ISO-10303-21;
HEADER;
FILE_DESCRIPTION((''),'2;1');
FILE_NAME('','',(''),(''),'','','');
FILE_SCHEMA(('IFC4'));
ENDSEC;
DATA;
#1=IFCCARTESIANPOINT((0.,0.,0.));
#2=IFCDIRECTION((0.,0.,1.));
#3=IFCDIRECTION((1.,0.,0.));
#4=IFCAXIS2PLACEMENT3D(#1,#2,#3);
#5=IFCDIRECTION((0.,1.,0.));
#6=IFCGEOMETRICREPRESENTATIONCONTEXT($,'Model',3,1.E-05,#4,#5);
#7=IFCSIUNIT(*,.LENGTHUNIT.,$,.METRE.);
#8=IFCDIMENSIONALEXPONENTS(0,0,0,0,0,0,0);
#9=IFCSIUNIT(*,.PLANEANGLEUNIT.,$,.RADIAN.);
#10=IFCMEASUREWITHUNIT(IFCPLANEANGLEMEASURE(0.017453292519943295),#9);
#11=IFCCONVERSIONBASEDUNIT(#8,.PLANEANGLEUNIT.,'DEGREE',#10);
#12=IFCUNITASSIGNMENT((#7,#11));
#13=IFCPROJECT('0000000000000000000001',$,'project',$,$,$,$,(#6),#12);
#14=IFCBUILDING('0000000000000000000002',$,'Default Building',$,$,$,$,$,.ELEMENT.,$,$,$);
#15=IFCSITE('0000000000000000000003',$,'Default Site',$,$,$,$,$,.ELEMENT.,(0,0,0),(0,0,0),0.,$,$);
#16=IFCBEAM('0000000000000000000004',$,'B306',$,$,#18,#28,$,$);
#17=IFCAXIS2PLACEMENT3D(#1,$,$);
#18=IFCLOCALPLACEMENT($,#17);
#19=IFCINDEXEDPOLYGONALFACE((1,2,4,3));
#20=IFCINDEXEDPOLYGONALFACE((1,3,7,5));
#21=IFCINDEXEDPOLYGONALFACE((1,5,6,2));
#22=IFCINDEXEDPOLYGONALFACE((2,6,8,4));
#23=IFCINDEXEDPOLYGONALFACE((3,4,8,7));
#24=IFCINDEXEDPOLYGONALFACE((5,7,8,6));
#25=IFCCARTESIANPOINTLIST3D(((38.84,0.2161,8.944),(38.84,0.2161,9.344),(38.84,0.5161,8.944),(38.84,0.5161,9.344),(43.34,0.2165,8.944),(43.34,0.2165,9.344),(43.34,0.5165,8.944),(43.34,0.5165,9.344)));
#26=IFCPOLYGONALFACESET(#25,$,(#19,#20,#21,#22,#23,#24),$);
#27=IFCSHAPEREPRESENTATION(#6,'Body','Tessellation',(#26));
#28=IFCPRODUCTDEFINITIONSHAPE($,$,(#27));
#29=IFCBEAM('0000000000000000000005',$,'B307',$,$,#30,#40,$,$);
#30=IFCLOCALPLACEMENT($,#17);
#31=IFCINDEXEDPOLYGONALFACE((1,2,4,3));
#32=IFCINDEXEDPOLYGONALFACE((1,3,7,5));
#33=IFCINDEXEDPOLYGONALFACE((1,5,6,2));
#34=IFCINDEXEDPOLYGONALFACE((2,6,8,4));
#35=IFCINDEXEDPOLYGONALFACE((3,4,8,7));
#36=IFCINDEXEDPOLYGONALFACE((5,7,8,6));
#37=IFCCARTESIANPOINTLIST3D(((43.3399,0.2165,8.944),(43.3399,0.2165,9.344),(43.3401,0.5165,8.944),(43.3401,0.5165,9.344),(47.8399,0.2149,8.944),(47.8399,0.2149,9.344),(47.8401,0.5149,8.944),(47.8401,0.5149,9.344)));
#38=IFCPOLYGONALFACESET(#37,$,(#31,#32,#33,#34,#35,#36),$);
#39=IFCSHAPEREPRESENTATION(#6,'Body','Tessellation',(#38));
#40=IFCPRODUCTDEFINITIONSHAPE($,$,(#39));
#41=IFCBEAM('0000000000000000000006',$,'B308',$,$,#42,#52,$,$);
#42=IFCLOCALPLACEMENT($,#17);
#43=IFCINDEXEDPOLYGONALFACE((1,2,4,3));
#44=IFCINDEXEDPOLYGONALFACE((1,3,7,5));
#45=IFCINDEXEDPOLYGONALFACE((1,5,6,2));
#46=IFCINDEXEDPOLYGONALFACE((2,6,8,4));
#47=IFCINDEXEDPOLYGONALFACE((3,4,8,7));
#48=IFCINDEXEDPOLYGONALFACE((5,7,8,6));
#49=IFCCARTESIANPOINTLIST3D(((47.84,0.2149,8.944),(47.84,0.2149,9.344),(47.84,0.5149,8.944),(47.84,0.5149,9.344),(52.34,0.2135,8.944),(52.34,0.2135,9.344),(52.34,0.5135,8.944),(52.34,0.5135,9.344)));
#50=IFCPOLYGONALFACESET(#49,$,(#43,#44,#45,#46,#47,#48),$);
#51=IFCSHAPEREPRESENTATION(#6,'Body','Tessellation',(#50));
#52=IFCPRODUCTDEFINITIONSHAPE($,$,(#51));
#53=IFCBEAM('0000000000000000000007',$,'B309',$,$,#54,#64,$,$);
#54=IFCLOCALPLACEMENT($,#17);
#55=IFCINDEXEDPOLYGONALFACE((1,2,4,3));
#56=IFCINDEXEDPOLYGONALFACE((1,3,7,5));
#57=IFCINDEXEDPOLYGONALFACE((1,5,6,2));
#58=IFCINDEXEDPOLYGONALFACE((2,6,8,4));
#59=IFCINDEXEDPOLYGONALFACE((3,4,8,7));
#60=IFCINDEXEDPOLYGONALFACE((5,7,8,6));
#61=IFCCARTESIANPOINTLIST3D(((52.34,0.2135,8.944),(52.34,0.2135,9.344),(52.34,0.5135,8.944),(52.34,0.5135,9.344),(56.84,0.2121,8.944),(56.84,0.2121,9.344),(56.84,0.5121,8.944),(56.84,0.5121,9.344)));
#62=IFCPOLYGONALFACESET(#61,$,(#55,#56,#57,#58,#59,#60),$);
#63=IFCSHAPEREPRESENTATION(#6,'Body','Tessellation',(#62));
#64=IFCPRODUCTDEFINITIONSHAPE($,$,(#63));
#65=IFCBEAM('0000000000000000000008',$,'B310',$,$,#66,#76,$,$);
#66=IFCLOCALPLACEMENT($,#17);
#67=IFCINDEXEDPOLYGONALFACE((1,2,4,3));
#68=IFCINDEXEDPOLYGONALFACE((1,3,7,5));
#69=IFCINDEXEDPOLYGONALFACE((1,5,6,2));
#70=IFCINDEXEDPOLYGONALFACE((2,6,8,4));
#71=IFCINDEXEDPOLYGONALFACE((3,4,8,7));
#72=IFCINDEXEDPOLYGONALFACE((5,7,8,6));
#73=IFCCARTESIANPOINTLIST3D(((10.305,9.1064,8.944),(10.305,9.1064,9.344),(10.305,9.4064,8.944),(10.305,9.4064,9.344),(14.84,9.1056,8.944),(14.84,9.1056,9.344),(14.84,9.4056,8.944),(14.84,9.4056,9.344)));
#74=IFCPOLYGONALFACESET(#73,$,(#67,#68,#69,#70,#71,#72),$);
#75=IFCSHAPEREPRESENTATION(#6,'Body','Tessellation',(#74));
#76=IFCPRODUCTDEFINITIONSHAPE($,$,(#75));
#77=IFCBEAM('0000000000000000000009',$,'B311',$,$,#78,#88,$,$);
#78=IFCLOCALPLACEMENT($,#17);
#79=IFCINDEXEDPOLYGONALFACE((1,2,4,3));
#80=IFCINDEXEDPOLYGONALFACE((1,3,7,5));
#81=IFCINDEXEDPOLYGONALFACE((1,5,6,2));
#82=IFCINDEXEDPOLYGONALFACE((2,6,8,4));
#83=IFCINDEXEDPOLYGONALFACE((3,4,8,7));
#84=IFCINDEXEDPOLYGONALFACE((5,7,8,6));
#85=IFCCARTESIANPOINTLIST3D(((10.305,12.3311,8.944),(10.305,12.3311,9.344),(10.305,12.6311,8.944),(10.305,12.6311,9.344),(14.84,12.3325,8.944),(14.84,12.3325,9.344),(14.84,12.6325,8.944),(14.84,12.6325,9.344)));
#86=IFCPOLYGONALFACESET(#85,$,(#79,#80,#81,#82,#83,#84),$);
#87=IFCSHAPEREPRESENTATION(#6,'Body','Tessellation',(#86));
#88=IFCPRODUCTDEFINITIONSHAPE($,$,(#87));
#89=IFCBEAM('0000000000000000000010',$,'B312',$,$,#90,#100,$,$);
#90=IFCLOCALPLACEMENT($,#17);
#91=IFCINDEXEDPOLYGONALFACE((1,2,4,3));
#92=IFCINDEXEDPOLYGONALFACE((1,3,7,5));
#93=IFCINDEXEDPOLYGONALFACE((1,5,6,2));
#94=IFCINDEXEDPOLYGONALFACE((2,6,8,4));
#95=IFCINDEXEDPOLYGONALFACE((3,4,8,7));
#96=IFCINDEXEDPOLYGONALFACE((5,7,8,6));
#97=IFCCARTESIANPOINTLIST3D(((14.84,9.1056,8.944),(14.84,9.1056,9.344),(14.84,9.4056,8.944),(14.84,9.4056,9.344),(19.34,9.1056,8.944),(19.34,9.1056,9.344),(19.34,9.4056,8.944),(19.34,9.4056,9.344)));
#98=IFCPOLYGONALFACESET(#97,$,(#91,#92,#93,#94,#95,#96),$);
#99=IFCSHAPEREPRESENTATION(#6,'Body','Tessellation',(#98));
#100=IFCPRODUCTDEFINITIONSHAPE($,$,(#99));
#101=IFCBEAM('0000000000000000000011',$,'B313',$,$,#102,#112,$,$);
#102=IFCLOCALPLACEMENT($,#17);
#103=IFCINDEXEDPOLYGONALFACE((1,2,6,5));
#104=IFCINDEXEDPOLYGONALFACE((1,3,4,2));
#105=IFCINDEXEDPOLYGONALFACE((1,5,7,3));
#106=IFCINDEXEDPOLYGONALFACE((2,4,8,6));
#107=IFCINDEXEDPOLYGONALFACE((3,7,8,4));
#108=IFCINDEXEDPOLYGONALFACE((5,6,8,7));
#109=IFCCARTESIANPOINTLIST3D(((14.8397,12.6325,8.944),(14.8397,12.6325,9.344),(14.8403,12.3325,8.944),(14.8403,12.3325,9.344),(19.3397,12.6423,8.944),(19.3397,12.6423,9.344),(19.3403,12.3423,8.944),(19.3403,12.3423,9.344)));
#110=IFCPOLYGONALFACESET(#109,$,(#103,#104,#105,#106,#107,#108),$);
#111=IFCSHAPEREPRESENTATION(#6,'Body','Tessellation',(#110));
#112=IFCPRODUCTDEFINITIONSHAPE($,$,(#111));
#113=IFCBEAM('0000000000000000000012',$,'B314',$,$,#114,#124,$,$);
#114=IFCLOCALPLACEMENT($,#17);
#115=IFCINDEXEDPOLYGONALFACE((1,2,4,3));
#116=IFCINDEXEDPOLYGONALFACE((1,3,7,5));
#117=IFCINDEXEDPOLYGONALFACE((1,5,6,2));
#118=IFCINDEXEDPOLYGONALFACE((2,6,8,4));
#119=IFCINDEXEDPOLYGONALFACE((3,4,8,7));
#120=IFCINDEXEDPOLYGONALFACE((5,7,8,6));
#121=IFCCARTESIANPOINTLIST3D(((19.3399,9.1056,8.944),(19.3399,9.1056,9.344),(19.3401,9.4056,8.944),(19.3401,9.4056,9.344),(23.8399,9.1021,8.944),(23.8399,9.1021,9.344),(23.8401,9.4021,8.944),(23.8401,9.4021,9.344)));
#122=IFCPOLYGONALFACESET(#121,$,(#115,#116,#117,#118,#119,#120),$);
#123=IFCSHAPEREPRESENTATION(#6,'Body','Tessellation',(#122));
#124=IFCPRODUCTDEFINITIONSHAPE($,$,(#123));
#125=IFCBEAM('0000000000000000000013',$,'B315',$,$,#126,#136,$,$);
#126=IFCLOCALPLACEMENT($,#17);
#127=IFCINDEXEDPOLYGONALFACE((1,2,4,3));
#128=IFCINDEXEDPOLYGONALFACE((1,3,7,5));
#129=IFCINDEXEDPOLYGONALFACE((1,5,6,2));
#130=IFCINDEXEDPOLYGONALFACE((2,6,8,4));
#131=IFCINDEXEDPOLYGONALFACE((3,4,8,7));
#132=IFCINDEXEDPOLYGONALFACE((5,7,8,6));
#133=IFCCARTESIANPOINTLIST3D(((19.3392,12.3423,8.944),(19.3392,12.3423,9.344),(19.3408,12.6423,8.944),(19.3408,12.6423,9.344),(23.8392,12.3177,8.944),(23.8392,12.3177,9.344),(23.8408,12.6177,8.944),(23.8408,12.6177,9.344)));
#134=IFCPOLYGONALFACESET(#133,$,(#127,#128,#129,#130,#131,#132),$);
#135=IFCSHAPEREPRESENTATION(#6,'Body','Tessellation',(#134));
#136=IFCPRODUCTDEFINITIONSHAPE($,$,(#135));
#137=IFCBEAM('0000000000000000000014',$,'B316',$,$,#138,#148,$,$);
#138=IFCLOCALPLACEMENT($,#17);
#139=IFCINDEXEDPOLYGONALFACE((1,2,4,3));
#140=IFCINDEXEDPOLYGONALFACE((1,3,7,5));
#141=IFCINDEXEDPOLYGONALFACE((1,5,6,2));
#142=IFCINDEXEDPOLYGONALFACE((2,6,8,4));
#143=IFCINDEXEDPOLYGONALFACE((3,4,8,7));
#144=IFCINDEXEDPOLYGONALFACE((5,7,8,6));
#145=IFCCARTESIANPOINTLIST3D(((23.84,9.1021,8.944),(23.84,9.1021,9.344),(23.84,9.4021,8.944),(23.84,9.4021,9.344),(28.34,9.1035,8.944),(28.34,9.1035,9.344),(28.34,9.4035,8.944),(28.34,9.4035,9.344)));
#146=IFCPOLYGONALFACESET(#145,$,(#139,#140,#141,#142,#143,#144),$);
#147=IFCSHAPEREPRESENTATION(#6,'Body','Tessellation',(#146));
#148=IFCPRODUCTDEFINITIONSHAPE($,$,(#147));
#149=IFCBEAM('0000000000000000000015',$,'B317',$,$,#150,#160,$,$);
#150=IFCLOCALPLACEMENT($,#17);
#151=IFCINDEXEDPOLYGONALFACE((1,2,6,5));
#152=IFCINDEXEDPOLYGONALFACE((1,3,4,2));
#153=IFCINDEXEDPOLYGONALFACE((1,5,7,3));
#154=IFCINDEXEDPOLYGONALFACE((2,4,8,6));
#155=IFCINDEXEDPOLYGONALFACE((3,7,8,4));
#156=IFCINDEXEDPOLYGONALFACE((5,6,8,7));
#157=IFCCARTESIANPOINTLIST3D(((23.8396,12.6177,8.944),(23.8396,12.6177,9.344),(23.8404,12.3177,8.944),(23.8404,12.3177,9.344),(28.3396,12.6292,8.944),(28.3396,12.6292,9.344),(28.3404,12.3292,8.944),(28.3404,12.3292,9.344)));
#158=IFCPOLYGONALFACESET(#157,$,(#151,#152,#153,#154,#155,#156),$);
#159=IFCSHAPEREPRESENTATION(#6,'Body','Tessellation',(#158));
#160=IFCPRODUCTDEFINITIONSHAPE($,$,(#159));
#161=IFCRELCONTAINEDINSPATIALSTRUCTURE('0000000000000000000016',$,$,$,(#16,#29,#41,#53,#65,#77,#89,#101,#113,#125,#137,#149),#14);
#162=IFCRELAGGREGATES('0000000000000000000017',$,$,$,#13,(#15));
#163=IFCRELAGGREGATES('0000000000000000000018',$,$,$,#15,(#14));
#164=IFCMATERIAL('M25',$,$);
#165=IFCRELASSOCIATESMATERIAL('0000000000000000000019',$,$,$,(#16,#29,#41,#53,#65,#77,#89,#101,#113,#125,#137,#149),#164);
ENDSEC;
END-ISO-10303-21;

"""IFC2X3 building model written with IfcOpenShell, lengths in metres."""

from ifc_helpers import new_model, entity, si_unit, converted_unit, direction, frame, frame_2d, origin_with_axes, place, context, project, spatial, rectangle, extrude, material, element, save


model = new_model("IFC2X3")

# Units and contexts
model_context = context("Model", 3, precision=1e-05, world=origin_with_axes(), true_north=direction((0.0, 1.0, 0.0)))
ifc_project = project(units=[si_unit("LENGTHUNIT", "METRE"), converted_unit("PLANEANGLEUNIT", "DEGREE", entity("IfcPlaneAngleMeasure", 0.017453292519943295), si_unit("PLANEANGLEUNIT", "RADIAN"), dimensions=[0, 0, 0, 0, 0, 0, 0])], contexts=[model_context])

# Site, building
site = spatial("IfcSite", under=ifc_project, Name="Default Site", CompositionType="ELEMENT", RefLatitude=(0, 0, 0), RefLongitude=(0, 0, 0), RefElevation=0.0)
building = spatial("IfcBuilding", under=site, Name="Default Building", CompositionType="ELEMENT")

# Beams
ifc_material = material(Name="M25")
placement = place(None, origin_with_axes())
element("IfcBeam", 1, at=placement, inside=building, material=ifc_material, Name="B306", context=model_context, shape_type="SweptSolid", body=[
    extrude(rectangle(XDim=0.3, YDim=0.4, at=frame_2d((0.0, 0.0), x_axis=(0.0, 1.0, 0.0))), frame((38.84, 0.3661, 9.144), z_axis=(1.0, 0.000077, 0.0), x_axis=(0.0, 0.0, -1.0)), (0.0, 0.0, 1.0), 4.5),
])
element("IfcBeam", 2, at=placement, inside=building, material=ifc_material, Name="B307", context=model_context, shape_type="SweptSolid", body=[
    extrude(rectangle(XDim=0.3, YDim=0.4, at=frame_2d((0.0, 0.0), x_axis=(0.0, 1.0, 0.0))), frame((43.34, 0.3665, 9.144), z_axis=(1.0, -0.000358, 0.0), x_axis=(0.0, 0.0, -1.0)), (0.0, 0.0, 1.0), 4.5),
])
element("IfcBeam", 3, at=placement, inside=building, material=ifc_material, Name="B308", context=model_context, shape_type="SweptSolid", body=[
    extrude(rectangle(XDim=0.3, YDim=0.4, at=frame_2d((0.0, 0.0), x_axis=(0.0, 1.0, 0.0))), frame((47.84, 0.3649, 9.144), z_axis=(1.0, -0.000297, 0.0), x_axis=(0.0, 0.0, -1.0)), (0.0, 0.0, 1.0), 4.5),
])
element("IfcBeam", 4, at=placement, inside=building, material=ifc_material, Name="B309", context=model_context, shape_type="SweptSolid", body=[
    extrude(rectangle(XDim=0.3, YDim=0.4, at=frame_2d((0.0, 0.0), x_axis=(0.0, 1.0, 0.0))), frame((52.34, 0.3635, 9.144), z_axis=(1.0, -0.000311, 0.0), x_axis=(0.0, 0.0, -1.0)), (0.0, 0.0, 1.0), 4.5),
])
element("IfcBeam", 5, at=placement, inside=building, material=ifc_material, Name="B310", context=model_context, shape_type="SweptSolid", body=[
    extrude(rectangle(XDim=0.3, YDim=0.4, at=frame_2d((0.0, 0.0), x_axis=(0.0, 1.0, 0.0))), frame((10.305, 9.2564, 9.144), z_axis=(1.0, -0.000182, 0.0), x_axis=(0.0, 0.0, -1.0)), (0.0, 0.0, 1.0), 4.535),
])
element("IfcBeam", 6, at=placement, inside=building, material=ifc_material, Name="B311", context=model_context, shape_type="SweptSolid", body=[
    extrude(rectangle(XDim=0.3, YDim=0.4, at=frame_2d((0.0, 0.0), x_axis=(0.0, 1.0, 0.0))), frame((10.305, 12.4811, 9.144), z_axis=(1.0, 0.000301, 0.0), x_axis=(0.0, 0.0, -1.0)), (0.0, 0.0, 1.0), 4.535),
])
element("IfcBeam", 7, at=placement, inside=building, material=ifc_material, Name="B312", context=model_context, shape_type="SweptSolid", body=[
    extrude(rectangle(XDim=0.3, YDim=0.4, at=frame_2d((0.0, 0.0), x_axis=(0.0, 1.0, 0.0))), frame((14.84, 9.2556, 9.144), z_axis=(1.0, 0.000013, 0.0), x_axis=(0.0, 0.0, -1.0)), (0.0, 0.0, 1.0), 4.5),
])
element("IfcBeam", 8, at=placement, inside=building, material=ifc_material, Name="B313", context=model_context, shape_type="SweptSolid", body=[
    extrude(rectangle(XDim=0.3, YDim=0.4, at=frame_2d((0.0, 0.0), x_axis=(0.0, 1.0, 0.0))), frame((14.84, 12.4825, 9.144), z_axis=(0.999998, 0.002176, 0.0), x_axis=(0.0, 0.0, -1.0)), (0.0, 0.0, 1.0), 4.5),
])
element("IfcBeam", 9, at=placement, inside=building, material=ifc_material, Name="B314", context=model_context, shape_type="SweptSolid", body=[
    extrude(rectangle(XDim=0.3, YDim=0.4, at=frame_2d((0.0, 0.0), x_axis=(0.0, 1.0, 0.0))), frame((19.34, 9.2556, 9.144), z_axis=(1.0, -0.000779, 0.0), x_axis=(0.0, 0.0, -1.0)), (0.0, 0.0, 1.0), 4.5),
])
element("IfcBeam", 10, at=placement, inside=building, material=ifc_material, Name="B315", context=model_context, shape_type="SweptSolid", body=[
    extrude(rectangle(XDim=0.3, YDim=0.4, at=frame_2d((0.0, 0.0), x_axis=(0.0, 1.0, 0.0))), frame((19.34, 12.4923, 9.144), z_axis=(0.999985, -0.005463, 0.0), x_axis=(0.0, 0.0, -1.0)), (0.0, 0.0, 1.0), 4.5001),
])
element("IfcBeam", 11, at=placement, inside=building, material=ifc_material, Name="B316", context=model_context, shape_type="SweptSolid", body=[
    extrude(rectangle(XDim=0.3, YDim=0.4, at=frame_2d((0.0, 0.0), x_axis=(0.0, 1.0, 0.0))), frame((23.84, 9.2521, 9.144), z_axis=(1.0, 0.000307, 0.0), x_axis=(0.0, 0.0, -1.0)), (0.0, 0.0, 1.0), 4.5),
])
element("IfcBeam", 12, at=placement, inside=building, material=ifc_material, Name="B317", context=model_context, shape_type="SweptSolid", body=[
    extrude(rectangle(XDim=0.3, YDim=0.4, at=frame_2d((0.0, 0.0), x_axis=(0.0, 1.0, 0.0))), frame((23.84, 12.4677, 9.144), z_axis=(0.999997, 0.002551, 0.0), x_axis=(0.0, 0.0, -1.0)), (0.0, 0.0, 1.0), 4.5),
])

save(model, "model.ifc")
